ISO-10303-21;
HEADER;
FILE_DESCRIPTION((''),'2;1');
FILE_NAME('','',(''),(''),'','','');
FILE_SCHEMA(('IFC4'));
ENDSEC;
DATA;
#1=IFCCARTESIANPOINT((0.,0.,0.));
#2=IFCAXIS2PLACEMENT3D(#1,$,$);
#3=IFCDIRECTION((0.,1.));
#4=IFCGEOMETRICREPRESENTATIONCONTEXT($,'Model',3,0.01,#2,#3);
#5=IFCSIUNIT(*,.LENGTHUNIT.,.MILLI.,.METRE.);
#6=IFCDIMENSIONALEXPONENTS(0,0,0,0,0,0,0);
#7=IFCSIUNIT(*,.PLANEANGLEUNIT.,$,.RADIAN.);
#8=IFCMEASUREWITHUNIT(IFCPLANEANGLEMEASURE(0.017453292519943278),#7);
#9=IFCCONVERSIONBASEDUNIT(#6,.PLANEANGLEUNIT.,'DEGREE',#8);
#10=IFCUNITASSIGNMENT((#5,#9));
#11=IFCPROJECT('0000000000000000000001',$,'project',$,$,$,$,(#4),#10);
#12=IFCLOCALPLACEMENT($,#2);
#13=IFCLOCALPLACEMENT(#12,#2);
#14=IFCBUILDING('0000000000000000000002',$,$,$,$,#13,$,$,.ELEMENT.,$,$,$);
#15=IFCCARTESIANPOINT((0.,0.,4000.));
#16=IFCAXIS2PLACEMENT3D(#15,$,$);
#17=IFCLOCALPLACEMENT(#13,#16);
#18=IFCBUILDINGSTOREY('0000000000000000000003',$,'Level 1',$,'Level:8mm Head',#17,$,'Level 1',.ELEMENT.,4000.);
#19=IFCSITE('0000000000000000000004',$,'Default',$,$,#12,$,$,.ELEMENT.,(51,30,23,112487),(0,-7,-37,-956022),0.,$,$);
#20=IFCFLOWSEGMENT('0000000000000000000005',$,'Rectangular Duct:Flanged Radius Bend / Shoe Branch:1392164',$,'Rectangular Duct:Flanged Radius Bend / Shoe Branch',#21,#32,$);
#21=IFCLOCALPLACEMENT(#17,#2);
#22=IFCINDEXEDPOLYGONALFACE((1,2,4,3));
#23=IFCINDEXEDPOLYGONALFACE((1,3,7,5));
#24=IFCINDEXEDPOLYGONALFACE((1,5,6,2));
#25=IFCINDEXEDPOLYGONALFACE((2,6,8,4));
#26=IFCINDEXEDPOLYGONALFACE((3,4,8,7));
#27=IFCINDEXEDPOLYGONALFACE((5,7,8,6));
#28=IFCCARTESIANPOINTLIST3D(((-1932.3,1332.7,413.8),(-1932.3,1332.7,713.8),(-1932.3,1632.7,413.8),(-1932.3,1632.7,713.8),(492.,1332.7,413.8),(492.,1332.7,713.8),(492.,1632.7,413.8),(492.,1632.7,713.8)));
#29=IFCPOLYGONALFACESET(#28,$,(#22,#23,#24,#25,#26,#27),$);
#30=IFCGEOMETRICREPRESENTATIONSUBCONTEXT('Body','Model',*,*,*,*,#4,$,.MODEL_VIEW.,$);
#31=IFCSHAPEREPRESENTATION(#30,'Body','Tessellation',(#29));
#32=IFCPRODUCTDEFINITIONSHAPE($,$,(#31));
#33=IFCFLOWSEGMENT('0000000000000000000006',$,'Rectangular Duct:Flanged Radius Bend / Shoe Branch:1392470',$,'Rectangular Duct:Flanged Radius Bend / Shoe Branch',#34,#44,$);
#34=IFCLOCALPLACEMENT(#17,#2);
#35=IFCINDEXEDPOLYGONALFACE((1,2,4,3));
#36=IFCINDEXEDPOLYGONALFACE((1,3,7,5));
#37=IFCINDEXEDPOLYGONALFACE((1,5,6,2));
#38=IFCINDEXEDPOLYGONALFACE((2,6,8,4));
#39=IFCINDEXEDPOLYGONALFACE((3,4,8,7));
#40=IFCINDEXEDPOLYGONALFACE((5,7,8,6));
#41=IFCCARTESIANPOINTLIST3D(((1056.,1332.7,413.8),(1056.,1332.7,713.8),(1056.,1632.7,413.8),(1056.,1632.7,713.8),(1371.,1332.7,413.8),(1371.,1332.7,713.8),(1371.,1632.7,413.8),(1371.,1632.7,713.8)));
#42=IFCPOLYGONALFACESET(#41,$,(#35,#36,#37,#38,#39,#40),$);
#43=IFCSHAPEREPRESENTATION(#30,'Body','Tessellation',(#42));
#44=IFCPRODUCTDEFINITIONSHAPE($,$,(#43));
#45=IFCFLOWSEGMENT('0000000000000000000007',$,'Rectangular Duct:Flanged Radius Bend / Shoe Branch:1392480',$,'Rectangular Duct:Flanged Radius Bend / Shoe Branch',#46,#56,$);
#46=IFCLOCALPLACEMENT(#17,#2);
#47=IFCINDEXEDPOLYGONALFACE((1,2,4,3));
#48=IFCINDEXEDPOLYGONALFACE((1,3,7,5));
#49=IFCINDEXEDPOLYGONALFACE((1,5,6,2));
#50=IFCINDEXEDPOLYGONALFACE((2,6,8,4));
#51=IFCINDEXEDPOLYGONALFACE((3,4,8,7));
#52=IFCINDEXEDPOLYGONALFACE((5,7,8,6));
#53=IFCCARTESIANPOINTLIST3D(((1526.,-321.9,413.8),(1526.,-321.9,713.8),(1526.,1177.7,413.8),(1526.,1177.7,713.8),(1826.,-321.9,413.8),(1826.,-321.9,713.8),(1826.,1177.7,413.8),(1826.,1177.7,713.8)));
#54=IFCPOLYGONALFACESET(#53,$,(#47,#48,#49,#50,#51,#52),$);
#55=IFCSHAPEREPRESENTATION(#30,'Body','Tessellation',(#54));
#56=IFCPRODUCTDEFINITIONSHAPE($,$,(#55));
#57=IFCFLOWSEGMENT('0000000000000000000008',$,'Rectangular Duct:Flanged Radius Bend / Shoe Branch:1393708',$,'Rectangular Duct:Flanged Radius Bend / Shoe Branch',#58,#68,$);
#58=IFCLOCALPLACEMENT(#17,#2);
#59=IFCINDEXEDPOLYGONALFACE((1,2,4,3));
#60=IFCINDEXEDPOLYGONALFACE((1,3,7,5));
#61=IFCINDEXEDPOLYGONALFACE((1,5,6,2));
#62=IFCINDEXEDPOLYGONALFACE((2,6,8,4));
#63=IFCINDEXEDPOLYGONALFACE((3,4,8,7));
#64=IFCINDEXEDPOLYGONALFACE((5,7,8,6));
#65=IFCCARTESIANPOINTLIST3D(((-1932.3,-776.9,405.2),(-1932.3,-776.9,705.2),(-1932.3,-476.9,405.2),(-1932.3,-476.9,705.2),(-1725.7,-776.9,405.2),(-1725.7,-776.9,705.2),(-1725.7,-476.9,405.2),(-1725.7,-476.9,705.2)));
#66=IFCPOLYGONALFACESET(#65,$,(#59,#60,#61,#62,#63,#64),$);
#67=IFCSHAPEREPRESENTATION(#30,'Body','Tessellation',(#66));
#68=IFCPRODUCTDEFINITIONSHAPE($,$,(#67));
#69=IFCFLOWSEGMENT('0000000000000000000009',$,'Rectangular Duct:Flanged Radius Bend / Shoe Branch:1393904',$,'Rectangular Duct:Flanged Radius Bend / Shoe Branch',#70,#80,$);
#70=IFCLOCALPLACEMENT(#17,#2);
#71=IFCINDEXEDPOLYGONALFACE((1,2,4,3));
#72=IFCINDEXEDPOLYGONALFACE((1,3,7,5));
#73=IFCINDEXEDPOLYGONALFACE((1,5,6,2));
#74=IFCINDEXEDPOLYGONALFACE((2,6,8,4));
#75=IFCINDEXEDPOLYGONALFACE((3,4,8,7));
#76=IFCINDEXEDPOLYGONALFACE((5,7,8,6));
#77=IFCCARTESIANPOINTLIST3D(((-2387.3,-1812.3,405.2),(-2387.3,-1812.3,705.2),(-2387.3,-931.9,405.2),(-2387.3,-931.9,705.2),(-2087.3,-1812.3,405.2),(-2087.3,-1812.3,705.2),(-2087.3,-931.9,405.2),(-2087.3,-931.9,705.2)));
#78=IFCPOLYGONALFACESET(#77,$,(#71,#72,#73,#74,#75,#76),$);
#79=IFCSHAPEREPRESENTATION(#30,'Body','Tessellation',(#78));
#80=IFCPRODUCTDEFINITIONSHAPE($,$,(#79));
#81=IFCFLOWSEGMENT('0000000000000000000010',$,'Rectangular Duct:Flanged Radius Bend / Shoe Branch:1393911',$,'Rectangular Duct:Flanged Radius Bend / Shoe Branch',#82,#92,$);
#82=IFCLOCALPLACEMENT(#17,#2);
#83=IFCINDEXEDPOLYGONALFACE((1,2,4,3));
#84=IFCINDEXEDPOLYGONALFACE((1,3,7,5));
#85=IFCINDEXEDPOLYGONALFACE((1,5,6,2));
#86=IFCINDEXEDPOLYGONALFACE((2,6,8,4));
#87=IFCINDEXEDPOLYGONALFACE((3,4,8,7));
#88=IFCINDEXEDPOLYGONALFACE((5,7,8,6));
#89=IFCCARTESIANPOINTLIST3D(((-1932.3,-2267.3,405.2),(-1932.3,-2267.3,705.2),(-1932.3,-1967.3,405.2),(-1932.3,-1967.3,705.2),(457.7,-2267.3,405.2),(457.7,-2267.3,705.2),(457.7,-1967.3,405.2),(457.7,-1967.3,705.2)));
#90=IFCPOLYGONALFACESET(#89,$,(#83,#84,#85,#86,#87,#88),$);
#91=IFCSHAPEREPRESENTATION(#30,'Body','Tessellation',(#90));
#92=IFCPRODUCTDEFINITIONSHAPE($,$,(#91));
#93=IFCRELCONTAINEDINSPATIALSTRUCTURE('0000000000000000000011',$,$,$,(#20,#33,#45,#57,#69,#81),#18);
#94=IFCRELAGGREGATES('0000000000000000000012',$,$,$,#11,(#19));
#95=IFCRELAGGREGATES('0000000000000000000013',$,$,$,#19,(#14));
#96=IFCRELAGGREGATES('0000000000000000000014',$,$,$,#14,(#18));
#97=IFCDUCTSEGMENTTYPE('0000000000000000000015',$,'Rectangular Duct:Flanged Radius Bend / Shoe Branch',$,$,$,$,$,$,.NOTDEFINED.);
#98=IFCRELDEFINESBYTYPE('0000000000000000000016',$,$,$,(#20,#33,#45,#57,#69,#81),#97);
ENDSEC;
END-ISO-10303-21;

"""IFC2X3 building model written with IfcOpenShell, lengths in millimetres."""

from ifc_helpers import new_model, entity, si_unit, converted_unit, direction, frame, frame_2d, origin, origin_2d_with_axis, place, context, subcontext, project, spatial, rectangle, extrude, type_object, element, save


model = new_model("IFC2X3")

# Units and contexts
model_context = context("Model", 3, precision=0.01, world=origin(), true_north=direction((0.0, 1.0)))
body_context = subcontext(model_context, "Body", "Model", "MODEL_VIEW")
ifc_project = project(units=[si_unit("LENGTHUNIT", "METRE", prefix="MILLI"), converted_unit("PLANEANGLEUNIT", "DEGREE", entity("IfcPlaneAngleMeasure", 0.017453292519943278), si_unit("PLANEANGLEUNIT", "RADIAN"), dimensions=[0, 0, 0, 0, 0, 0, 0])], contexts=[model_context])

# Site, building, storey
site_placement = place(None, origin())
site = spatial("IfcSite", under=ifc_project, at=site_placement, Name="Default", CompositionType="ELEMENT", RefLatitude=(51, 30, 23, 112487), RefLongitude=(0, -7, -37, -956022), RefElevation=0.0)
building_placement = place(site_placement, origin())
building = spatial("IfcBuilding", under=site, at=building_placement, CompositionType="ELEMENT")
storey_placement = place(building_placement, frame((0.0, 0.0, 4000.0)))
storey = spatial("IfcBuildingStorey", under=building, at=storey_placement, Name="Level 1", ObjectType="Level:8mm Head", LongName="Level 1", CompositionType="ELEMENT", Elevation=4000.0)

# Flow segments
duct_segment_type = type_object("IfcDuctSegmentType", Name="Rectangular Duct:Flanged Radius Bend / Shoe Branch", PredefinedType="NOTDEFINED")
flow_segment_1_placement = place(storey_placement, origin())
element("IfcFlowSegment", 1, at=flow_segment_1_placement, inside=storey, type_object=duct_segment_type, Name="Rectangular Duct:Flanged Radius Bend / Shoe Branch:1392164", ObjectType="Rectangular Duct:Flanged Radius Bend / Shoe Branch", context=body_context, shape_type="SweptSolid", body=[
    extrude(rectangle(XDim=2424.3, YDim=300.0, at=frame_2d((0.0, 0.0), x_axis=(1.0, 0.0))), frame((-720.1, 1482.7, 413.8)), (0.0, 0.0, 1.0), 300.0),
])
flow_segment_2_placement = place(storey_placement, origin())
element("IfcFlowSegment", 2, at=flow_segment_2_placement, inside=storey, type_object=duct_segment_type, Name="Rectangular Duct:Flanged Radius Bend / Shoe Branch:1392470", ObjectType="Rectangular Duct:Flanged Radius Bend / Shoe Branch", context=body_context, shape_type="SweptSolid", body=[
    extrude(rectangle(XDim=315.0, YDim=300.0, at=frame_2d((0.0, 0.0), x_axis=(1.0, 0.0))), frame((1213.5, 1482.7, 413.8)), (0.0, 0.0, 1.0), 300.0),
])
flow_segment_3_placement = place(storey_placement, origin())
element("IfcFlowSegment", 3, at=flow_segment_3_placement, inside=storey, type_object=duct_segment_type, Name="Rectangular Duct:Flanged Radius Bend / Shoe Branch:1392480", ObjectType="Rectangular Duct:Flanged Radius Bend / Shoe Branch", context=body_context, shape_type="SweptSolid", body=[
    extrude(rectangle(XDim=1499.6, YDim=300.0, at=origin_2d_with_axis()), frame((1676.0, 427.9, 413.8), z_axis=(0.0, 0.0, 1.0), x_axis=(0.0, -1.0, 0.0)), (0.0, 0.0, 1.0), 300.0),
])
flow_segment_4_placement = place(storey_placement, origin())
element("IfcFlowSegment", 4, at=flow_segment_4_placement, inside=storey, type_object=duct_segment_type, Name="Rectangular Duct:Flanged Radius Bend / Shoe Branch:1393708", ObjectType="Rectangular Duct:Flanged Radius Bend / Shoe Branch", context=body_context, shape_type="SweptSolid", body=[
    extrude(rectangle(XDim=206.6, YDim=300.0, at=frame_2d((0.0, 0.0), x_axis=(1.0, 0.0))), frame((-1829.0, -626.9, 405.2), z_axis=(0.0, 0.0, 1.0), x_axis=(-1.0, 0.0, 0.0)), (0.0, 0.0, 1.0), 300.0),
])
flow_segment_5_placement = place(storey_placement, origin())
element("IfcFlowSegment", 5, at=flow_segment_5_placement, inside=storey, type_object=duct_segment_type, Name="Rectangular Duct:Flanged Radius Bend / Shoe Branch:1393904", ObjectType="Rectangular Duct:Flanged Radius Bend / Shoe Branch", context=body_context, shape_type="SweptSolid", body=[
    extrude(rectangle(XDim=880.4, YDim=300.0, at=frame_2d((0.0, 0.0), x_axis=(1.0, 0.0))), frame((-2237.3, -1372.1, 405.2), z_axis=(0.0, 0.0, 1.0), x_axis=(0.0, -1.0, 0.0)), (0.0, 0.0, 1.0), 300.0),
])
flow_segment_6_placement = place(storey_placement, origin())
element("IfcFlowSegment", 6, at=flow_segment_6_placement, inside=storey, type_object=duct_segment_type, Name="Rectangular Duct:Flanged Radius Bend / Shoe Branch:1393911", ObjectType="Rectangular Duct:Flanged Radius Bend / Shoe Branch", context=body_context, shape_type="SweptSolid", body=[
    extrude(rectangle(XDim=2390.0, YDim=300.0, at=origin_2d_with_axis()), frame((-737.3, -2117.3, 405.2)), (0.0, 0.0, 1.0), 300.0),
])

save(model, "model.ifc")
